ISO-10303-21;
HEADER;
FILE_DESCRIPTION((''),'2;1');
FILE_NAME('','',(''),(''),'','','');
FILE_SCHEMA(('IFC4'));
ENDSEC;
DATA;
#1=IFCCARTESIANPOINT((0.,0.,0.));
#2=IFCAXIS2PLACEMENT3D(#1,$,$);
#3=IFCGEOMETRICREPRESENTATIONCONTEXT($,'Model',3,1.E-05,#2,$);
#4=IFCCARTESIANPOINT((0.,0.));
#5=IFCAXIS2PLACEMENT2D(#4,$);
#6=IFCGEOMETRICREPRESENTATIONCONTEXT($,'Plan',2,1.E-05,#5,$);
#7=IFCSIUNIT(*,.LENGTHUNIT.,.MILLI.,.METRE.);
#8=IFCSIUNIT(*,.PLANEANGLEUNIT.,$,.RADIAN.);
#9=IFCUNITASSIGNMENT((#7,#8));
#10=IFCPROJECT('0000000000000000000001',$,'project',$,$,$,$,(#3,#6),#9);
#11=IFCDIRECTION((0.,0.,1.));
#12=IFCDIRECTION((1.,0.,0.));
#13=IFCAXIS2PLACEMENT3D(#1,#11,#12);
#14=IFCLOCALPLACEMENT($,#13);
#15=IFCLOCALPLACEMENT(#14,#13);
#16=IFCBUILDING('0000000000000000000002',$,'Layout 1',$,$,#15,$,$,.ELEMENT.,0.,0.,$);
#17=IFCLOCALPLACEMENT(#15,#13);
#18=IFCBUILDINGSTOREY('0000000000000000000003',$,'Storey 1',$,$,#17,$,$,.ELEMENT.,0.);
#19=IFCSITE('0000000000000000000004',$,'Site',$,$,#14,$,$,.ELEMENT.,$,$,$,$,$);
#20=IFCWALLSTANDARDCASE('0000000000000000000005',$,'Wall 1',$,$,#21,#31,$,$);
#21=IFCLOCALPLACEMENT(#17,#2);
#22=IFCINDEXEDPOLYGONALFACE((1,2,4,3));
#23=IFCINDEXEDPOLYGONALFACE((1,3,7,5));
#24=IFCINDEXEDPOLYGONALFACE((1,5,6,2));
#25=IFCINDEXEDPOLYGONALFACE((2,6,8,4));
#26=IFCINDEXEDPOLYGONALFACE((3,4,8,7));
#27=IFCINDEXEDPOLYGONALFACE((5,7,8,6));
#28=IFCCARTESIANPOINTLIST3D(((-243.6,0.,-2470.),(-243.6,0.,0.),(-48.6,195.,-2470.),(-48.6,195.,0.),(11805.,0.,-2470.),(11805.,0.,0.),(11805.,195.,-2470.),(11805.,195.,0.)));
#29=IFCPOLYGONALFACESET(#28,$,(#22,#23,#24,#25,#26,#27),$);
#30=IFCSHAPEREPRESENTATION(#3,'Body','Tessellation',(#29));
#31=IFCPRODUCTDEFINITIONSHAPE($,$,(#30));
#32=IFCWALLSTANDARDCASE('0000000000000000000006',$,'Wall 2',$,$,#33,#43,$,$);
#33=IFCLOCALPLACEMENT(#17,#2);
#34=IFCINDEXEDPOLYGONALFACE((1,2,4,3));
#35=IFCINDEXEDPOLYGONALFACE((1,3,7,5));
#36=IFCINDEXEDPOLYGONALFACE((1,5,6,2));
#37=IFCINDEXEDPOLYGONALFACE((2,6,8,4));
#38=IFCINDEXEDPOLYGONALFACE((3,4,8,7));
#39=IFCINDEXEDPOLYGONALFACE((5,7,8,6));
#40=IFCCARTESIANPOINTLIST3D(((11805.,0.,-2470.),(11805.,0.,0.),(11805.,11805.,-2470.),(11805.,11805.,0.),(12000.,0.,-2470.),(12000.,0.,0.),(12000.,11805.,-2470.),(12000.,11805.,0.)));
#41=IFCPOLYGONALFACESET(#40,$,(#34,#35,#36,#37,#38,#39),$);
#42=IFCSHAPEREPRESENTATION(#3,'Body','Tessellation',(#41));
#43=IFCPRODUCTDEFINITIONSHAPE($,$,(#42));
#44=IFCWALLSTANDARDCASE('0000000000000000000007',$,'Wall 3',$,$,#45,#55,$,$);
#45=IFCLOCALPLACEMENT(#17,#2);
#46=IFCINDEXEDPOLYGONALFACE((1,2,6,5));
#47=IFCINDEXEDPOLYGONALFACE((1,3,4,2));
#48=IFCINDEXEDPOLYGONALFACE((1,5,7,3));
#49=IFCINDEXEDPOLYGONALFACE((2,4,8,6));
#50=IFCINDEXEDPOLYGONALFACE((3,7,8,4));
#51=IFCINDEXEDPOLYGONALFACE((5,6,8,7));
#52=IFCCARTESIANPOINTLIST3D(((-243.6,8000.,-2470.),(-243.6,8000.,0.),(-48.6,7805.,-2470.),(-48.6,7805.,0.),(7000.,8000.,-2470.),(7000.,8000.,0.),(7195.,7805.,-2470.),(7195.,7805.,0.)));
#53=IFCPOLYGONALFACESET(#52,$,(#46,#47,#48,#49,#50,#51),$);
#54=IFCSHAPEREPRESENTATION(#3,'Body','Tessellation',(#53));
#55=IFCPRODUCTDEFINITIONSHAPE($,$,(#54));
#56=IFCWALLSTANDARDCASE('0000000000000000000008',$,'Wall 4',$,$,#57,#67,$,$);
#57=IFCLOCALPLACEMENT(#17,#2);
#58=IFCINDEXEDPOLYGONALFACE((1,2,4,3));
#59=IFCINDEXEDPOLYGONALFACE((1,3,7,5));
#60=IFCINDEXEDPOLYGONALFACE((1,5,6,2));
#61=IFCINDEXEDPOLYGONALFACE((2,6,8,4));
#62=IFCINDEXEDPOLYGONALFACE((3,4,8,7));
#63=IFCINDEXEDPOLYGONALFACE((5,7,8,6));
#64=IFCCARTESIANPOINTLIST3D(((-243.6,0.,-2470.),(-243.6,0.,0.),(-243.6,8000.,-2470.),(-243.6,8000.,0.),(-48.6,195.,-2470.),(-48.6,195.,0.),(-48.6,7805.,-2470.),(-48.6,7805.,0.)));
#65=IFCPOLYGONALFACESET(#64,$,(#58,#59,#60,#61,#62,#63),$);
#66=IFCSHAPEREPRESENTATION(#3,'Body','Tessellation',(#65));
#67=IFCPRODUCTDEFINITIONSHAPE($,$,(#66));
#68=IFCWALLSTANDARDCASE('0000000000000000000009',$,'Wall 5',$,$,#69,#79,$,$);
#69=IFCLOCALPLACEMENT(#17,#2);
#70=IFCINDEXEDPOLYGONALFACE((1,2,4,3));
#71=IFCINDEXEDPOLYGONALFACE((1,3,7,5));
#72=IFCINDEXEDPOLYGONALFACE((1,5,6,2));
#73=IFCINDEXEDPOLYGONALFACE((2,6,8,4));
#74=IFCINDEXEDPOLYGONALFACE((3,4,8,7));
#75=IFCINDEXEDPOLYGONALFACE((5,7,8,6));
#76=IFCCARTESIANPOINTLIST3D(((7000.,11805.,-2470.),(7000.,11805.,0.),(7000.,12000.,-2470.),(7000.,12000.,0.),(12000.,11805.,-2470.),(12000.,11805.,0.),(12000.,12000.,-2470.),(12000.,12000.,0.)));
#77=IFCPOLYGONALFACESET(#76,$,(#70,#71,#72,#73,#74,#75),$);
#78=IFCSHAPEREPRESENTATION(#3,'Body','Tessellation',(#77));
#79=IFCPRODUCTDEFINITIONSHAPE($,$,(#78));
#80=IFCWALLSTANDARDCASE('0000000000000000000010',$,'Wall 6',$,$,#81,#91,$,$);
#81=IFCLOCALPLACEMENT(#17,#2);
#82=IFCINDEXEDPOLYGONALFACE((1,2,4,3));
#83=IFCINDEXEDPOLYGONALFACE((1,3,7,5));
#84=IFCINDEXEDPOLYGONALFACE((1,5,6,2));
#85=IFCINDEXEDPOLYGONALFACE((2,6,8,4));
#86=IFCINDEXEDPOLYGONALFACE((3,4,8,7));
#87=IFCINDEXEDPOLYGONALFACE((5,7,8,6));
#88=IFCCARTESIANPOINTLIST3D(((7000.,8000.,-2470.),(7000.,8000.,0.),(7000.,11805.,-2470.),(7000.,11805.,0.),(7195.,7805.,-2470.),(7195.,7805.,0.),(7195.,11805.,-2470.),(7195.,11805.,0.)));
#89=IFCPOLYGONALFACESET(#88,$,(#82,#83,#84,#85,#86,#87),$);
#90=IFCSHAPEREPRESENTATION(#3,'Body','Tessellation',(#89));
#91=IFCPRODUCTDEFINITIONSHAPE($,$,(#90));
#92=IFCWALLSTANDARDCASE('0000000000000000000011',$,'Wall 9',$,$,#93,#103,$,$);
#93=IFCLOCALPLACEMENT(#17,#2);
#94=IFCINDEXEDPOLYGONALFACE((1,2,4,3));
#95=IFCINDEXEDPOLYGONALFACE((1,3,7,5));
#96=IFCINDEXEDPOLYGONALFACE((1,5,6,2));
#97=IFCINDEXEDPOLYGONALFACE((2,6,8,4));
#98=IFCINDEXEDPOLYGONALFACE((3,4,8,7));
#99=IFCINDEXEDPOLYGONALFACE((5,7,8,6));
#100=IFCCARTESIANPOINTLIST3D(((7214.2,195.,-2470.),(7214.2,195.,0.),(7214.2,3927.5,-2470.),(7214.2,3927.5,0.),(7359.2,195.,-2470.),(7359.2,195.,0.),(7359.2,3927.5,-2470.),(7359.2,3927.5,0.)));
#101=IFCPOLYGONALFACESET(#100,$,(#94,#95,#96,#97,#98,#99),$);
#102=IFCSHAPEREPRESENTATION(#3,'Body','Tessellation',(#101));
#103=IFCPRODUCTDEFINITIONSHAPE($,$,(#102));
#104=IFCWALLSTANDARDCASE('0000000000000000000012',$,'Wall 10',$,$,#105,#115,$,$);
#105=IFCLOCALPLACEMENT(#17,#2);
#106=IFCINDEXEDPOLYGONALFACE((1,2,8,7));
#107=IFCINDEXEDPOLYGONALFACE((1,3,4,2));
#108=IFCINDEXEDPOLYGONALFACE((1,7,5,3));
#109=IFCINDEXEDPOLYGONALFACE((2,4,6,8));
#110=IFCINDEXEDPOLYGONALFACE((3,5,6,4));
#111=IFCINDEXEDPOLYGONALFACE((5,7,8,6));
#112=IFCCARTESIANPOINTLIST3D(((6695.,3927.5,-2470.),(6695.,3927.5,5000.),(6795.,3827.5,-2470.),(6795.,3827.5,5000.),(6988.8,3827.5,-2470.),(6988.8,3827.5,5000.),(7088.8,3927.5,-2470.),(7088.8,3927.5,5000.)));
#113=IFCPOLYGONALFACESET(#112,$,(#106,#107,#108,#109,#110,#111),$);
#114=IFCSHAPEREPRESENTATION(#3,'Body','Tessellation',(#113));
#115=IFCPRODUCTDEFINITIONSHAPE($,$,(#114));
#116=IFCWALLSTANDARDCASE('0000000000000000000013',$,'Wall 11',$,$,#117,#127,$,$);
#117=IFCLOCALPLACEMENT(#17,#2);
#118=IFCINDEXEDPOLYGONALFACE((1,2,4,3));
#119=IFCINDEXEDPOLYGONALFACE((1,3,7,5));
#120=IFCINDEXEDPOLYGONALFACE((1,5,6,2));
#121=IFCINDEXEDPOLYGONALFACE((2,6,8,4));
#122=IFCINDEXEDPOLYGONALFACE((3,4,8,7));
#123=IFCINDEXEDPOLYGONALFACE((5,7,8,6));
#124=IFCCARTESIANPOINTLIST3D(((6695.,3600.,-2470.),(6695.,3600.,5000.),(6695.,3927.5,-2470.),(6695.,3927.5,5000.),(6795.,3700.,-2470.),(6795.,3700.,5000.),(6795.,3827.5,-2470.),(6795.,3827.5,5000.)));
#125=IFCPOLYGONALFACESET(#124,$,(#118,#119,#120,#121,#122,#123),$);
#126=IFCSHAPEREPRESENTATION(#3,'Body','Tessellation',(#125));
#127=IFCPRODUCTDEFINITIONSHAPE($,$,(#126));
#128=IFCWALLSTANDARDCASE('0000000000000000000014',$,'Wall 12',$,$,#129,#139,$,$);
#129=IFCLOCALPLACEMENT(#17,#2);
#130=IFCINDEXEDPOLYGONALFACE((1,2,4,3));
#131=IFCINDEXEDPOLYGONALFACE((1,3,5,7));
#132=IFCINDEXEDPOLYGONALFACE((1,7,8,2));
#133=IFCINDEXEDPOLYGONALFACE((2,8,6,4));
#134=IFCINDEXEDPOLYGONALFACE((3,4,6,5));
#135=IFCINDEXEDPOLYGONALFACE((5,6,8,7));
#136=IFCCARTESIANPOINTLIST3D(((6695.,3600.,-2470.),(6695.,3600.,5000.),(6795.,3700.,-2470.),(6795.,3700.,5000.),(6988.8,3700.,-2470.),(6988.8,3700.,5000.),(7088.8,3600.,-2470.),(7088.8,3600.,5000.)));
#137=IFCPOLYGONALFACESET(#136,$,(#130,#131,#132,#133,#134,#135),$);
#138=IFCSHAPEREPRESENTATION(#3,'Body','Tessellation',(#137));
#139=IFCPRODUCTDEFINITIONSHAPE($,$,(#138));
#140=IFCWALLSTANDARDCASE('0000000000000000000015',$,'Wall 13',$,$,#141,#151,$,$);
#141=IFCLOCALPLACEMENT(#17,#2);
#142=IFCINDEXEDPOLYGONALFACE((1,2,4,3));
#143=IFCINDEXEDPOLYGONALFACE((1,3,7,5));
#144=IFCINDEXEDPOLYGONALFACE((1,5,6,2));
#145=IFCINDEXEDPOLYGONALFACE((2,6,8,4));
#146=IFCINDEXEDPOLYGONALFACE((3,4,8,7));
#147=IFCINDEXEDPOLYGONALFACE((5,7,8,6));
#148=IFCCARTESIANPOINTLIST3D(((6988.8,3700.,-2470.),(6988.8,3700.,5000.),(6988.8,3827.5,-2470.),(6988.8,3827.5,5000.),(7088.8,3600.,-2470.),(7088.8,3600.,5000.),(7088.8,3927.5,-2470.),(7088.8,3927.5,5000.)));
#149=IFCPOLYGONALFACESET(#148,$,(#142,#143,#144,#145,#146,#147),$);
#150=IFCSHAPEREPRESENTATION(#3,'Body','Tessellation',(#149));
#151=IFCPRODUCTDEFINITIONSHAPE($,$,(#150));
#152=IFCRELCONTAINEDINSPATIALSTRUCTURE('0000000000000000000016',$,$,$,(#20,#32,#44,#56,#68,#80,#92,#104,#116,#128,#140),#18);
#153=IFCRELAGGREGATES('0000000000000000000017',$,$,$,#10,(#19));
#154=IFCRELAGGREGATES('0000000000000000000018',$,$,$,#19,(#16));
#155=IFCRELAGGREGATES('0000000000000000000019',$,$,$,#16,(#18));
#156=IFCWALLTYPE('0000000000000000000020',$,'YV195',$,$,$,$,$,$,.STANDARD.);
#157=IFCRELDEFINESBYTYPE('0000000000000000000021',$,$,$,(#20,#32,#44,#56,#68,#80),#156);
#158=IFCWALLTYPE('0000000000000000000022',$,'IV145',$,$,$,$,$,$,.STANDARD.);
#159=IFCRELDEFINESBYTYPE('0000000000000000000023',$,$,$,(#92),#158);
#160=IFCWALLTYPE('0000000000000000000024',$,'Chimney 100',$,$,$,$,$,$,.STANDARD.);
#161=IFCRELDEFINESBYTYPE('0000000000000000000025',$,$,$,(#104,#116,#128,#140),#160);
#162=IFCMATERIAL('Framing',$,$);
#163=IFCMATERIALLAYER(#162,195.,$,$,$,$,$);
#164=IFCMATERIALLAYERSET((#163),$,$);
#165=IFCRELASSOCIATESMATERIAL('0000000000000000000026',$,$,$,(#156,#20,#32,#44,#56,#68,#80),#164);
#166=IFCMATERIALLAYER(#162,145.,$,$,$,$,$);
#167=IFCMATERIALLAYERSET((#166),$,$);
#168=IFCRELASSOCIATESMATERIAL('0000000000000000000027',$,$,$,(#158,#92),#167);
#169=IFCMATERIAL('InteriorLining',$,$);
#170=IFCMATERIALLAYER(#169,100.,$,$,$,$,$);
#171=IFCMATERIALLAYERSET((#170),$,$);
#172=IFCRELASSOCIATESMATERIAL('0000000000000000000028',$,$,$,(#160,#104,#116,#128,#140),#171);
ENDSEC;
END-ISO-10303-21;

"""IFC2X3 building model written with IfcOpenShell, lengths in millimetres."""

from ifc_helpers import new_model, si_unit, frame, origin, origin_with_axes, origin_2d, place, context, project, spatial, polyline, segment, composite_curve, outline, extrude, material, layer, layer_set, layer_usage, type_object, element, save


model = new_model("IFC2X3")

# Units and contexts
model_context = context("Model", 3, precision=1e-05, world=origin())
plan_context = context("Plan", 2, precision=1e-05, world=origin_2d())
ifc_project = project(units=[si_unit("LENGTHUNIT", "METRE", prefix="MILLI"), si_unit("PLANEANGLEUNIT", "RADIAN")], contexts=[model_context, plan_context])

# Site, building, storey
site_placement = place(None, origin_with_axes())
site = spatial("IfcSite", under=ifc_project, at=site_placement, Name="Site", CompositionType="ELEMENT")
building_placement = place(site_placement, origin_with_axes())
building = spatial("IfcBuilding", under=site, at=building_placement, Name="Layout 1", CompositionType="ELEMENT", ElevationOfRefHeight=0.0, ElevationOfTerrain=0.0)
storey_placement = place(building_placement, origin_with_axes())
storey = spatial("IfcBuildingStorey", under=building, at=storey_placement, Name="Storey 1", CompositionType="ELEMENT", Elevation=0.0)

# Walls
ifc_material_1 = material(Name="Framing")
ifc_layer_1 = layer(ifc_material_1, 195.0)
ifc_layer_set_1 = layer_set([ifc_layer_1])
ifc_layer_usage_1 = layer_usage(ifc_layer_set_1, "AXIS2", "POSITIVE", 0.0)
wall_type_1 = type_object("IfcWallType", Name="YV195", PredefinedType="STANDARD", material=ifc_layer_set_1)
wall_1_placement = place(storey_placement, frame((-243.6, 0.0, -2470.0), z_axis=(0.0, 0.0, 1.0), x_axis=(1.0, 0.0, 0.0)))
element("IfcWallStandardCase", 1, at=wall_1_placement, inside=storey, type_object=wall_type_1, material=ifc_layer_usage_1, Name="Wall 1", context=model_context, shape_type="SweptSolid", body=[
    extrude(outline(composite_curve([segment(polyline([(195.0, 195.0), (0.0, 0.0)]), True, "CONTINUOUS"), segment(polyline([(0.0, 0.0), (12048.6, 0.0)]), True, "CONTINUOUS"), segment(polyline([(12048.6, 0.0), (12048.6, 195.0)]), True, "CONTINUOUS"), segment(polyline([(12048.6, 195.0), (195.0, 195.0)]), True, "CONTINUOUS")], self_intersect=False)), origin_with_axes(), (0.0, 0.0, 1.0), 2470.0),
])
ifc_layer_usage_2 = layer_usage(ifc_layer_set_1, "AXIS2", "POSITIVE", 0.0)
wall_2_placement = place(storey_placement, frame((12000.0, 0.0, -2470.0), z_axis=(0.0, 0.0, 1.0), x_axis=(0.0, 1.0, 0.0)))
element("IfcWallStandardCase", 2, at=wall_2_placement, inside=storey, type_object=wall_type_1, material=ifc_layer_usage_2, Name="Wall 2", context=model_context, shape_type="SweptSolid", body=[
    extrude(outline(composite_curve([segment(polyline([(0.0, 195.0), (0.0, 0.0)]), True, "CONTINUOUS"), segment(polyline([(0.0, 0.0), (11805.0, 0.0)]), True, "CONTINUOUS"), segment(polyline([(11805.0, 0.0), (11805.0, 195.0)]), True, "CONTINUOUS"), segment(polyline([(11805.0, 195.0), (0.0, 195.0)]), True, "CONTINUOUS")], self_intersect=False)), origin_with_axes(), (0.0, 0.0, 1.0), 2470.0),
])
ifc_layer_usage_3 = layer_usage(ifc_layer_set_1, "AXIS2", "POSITIVE", 0.0)
wall_3_placement = place(storey_placement, frame((7000.0, 8000.0, -2470.0), z_axis=(0.0, 0.0, 1.0), x_axis=(-1.0, 0.0, 0.0)))
element("IfcWallStandardCase", 3, at=wall_3_placement, inside=storey, type_object=wall_type_1, material=ifc_layer_usage_3, Name="Wall 3", context=model_context, shape_type="SweptSolid", body=[
    extrude(outline(composite_curve([segment(polyline([(-195.0, 195.0), (0.0, 0.0)]), True, "CONTINUOUS"), segment(polyline([(0.0, 0.0), (7243.6, 0.0)]), True, "CONTINUOUS"), segment(polyline([(7243.6, 0.0), (7048.6, 195.0)]), True, "CONTINUOUS"), segment(polyline([(7048.6, 195.0), (-195.0, 195.0)]), True, "CONTINUOUS")], self_intersect=False)), origin_with_axes(), (0.0, 0.0, 1.0), 2470.0),
])
ifc_layer_usage_4 = layer_usage(ifc_layer_set_1, "AXIS2", "POSITIVE", 0.0)
wall_4_placement = place(storey_placement, frame((-243.6, 8000.0, -2470.0), z_axis=(0.0, 0.0, 1.0), x_axis=(0.0, -1.0, 0.0)))
element("IfcWallStandardCase", 4, at=wall_4_placement, inside=storey, type_object=wall_type_1, material=ifc_layer_usage_4, Name="Wall 4", context=model_context, shape_type="SweptSolid", body=[
    extrude(outline(composite_curve([segment(polyline([(195.0, 195.0), (0.0, 0.0)]), True, "CONTINUOUS"), segment(polyline([(0.0, 0.0), (8000.0, 0.0)]), True, "CONTINUOUS"), segment(polyline([(8000.0, 0.0), (7805.0, 195.0)]), True, "CONTINUOUS"), segment(polyline([(7805.0, 195.0), (195.0, 195.0)]), True, "CONTINUOUS")], self_intersect=False)), origin_with_axes(), (0.0, 0.0, 1.0), 2470.0),
])
ifc_layer_usage_5 = layer_usage(ifc_layer_set_1, "AXIS2", "POSITIVE", 0.0)
wall_5_placement = place(storey_placement, frame((12000.0, 12000.0, -2470.0), z_axis=(0.0, 0.0, 1.0), x_axis=(-1.0, 0.0, 0.0)))
element("IfcWallStandardCase", 5, at=wall_5_placement, inside=storey, type_object=wall_type_1, material=ifc_layer_usage_5, Name="Wall 5", context=model_context, shape_type="SweptSolid", body=[
    extrude(outline(composite_curve([segment(polyline([(0.0, 195.0), (0.0, 0.0)]), True, "CONTINUOUS"), segment(polyline([(0.0, 0.0), (5000.0, 0.0)]), True, "CONTINUOUS"), segment(polyline([(5000.0, 0.0), (5000.0, 195.0)]), True, "CONTINUOUS"), segment(polyline([(5000.0, 195.0), (0.0, 195.0)]), True, "CONTINUOUS")], self_intersect=False)), origin_with_axes(), (0.0, 0.0, 1.0), 2470.0),
])
ifc_layer_usage_6 = layer_usage(ifc_layer_set_1, "AXIS2", "POSITIVE", 0.0)
wall_6_placement = place(storey_placement, frame((7000.0, 11805.0, -2470.0), z_axis=(0.0, 0.0, 1.0), x_axis=(0.0, -1.0, 0.0)))
element("IfcWallStandardCase", 6, at=wall_6_placement, inside=storey, type_object=wall_type_1, material=ifc_layer_usage_6, Name="Wall 6", context=model_context, shape_type="SweptSolid", body=[
    extrude(outline(composite_curve([segment(polyline([(0.0, 195.0), (0.0, 0.0)]), True, "CONTINUOUS"), segment(polyline([(0.0, 0.0), (3805.0, 0.0)]), True, "CONTINUOUS"), segment(polyline([(3805.0, 0.0), (4000.0, 195.0)]), True, "CONTINUOUS"), segment(polyline([(4000.0, 195.0), (0.0, 195.0)]), True, "CONTINUOUS")], self_intersect=False)), origin_with_axes(), (0.0, 0.0, 1.0), 2470.0),
])
ifc_layer_2 = layer(ifc_material_1, 145.0)
ifc_layer_set_2 = layer_set([ifc_layer_2])
wall_type_2 = type_object("IfcWallType", Name="IV145", PredefinedType="STANDARD", material=ifc_layer_set_2)
ifc_layer_usage_7 = layer_usage(ifc_layer_set_2, "AXIS2", "POSITIVE", -72.5)
wall_7_placement = place(storey_placement, frame((7286.7, 0.0, -2470.0), z_axis=(0.0, 0.0, 1.0), x_axis=(0.0, 1.0, 0.0)))
element("IfcWallStandardCase", 7, at=wall_7_placement, inside=storey, type_object=wall_type_2, material=ifc_layer_usage_7, Name="Wall 9", context=model_context, shape_type="SweptSolid", body=[
    extrude(outline(composite_curve([segment(polyline([(195.0, 72.5), (195.0, -72.5)]), True, "CONTINUOUS"), segment(polyline([(195.0, -72.5), (3927.5, -72.5)]), True, "CONTINUOUS"), segment(polyline([(3927.5, -72.5), (3927.5, 72.5)]), True, "CONTINUOUS"), segment(polyline([(3927.5, 72.5), (195.0, 72.5)]), True, "CONTINUOUS")], self_intersect=False)), origin_with_axes(), (0.0, 0.0, 1.0), 2470.0),
])
ifc_material_2 = material(Name="InteriorLining")
ifc_layer_3 = layer(ifc_material_2, 100.0)
ifc_layer_set_3 = layer_set([ifc_layer_3])
ifc_layer_usage_8 = layer_usage(ifc_layer_set_3, "AXIS2", "POSITIVE", 0.0)
wall_type_3 = type_object("IfcWallType", Name="Chimney 100", PredefinedType="STANDARD", material=ifc_layer_set_3)
wall_8_placement = place(storey_placement, frame((7088.8, 3927.5, -2470.0), z_axis=(0.0, 0.0, 1.0), x_axis=(-1.0, 0.0, 0.0)))
element("IfcWallStandardCase", 8, at=wall_8_placement, inside=storey, type_object=wall_type_3, material=ifc_layer_usage_8, Name="Wall 10", context=model_context, shape_type="SweptSolid", body=[
    extrude(outline(composite_curve([segment(polyline([(100.0, 100.0), (0.0, 0.0)]), True, "CONTINUOUS"), segment(polyline([(0.0, 0.0), (393.8, 0.0)]), True, "CONTINUOUS"), segment(polyline([(393.8, 0.0), (293.8, 100.0)]), True, "CONTINUOUS"), segment(polyline([(293.8, 100.0), (100.0, 100.0)]), True, "CONTINUOUS")], self_intersect=False)), origin_with_axes(), (0.0, 0.0, 1.0), 7470.0),
])
ifc_layer_usage_9 = layer_usage(ifc_layer_set_3, "AXIS2", "POSITIVE", 0.0)
wall_9_placement = place(storey_placement, frame((6695.0, 3927.5, -2470.0), z_axis=(0.0, 0.0, 1.0), x_axis=(0.0, -1.0, 0.0)))
element("IfcWallStandardCase", 9, at=wall_9_placement, inside=storey, type_object=wall_type_3, material=ifc_layer_usage_9, Name="Wall 11", context=model_context, shape_type="SweptSolid", body=[
    extrude(outline(composite_curve([segment(polyline([(100.0, 100.0), (0.0, 0.0)]), True, "CONTINUOUS"), segment(polyline([(0.0, 0.0), (327.5, 0.0)]), True, "CONTINUOUS"), segment(polyline([(327.5, 0.0), (227.5, 100.0)]), True, "CONTINUOUS"), segment(polyline([(227.5, 100.0), (100.0, 100.0)]), True, "CONTINUOUS")], self_intersect=False)), origin_with_axes(), (0.0, 0.0, 1.0), 7470.0),
])
ifc_layer_usage_10 = layer_usage(ifc_layer_set_3, "AXIS2", "POSITIVE", 0.0)
wall_10_placement = place(storey_placement, frame((6695.0, 3600.0, -2470.0), z_axis=(0.0, 0.0, 1.0), x_axis=(1.0, 0.0, 0.0)))
element("IfcWallStandardCase", 10, at=wall_10_placement, inside=storey, type_object=wall_type_3, material=ifc_layer_usage_10, Name="Wall 12", context=model_context, shape_type="SweptSolid", body=[
    extrude(outline(composite_curve([segment(polyline([(100.0, 100.0), (0.0, 0.0)]), True, "CONTINUOUS"), segment(polyline([(0.0, 0.0), (393.8, 0.0)]), True, "CONTINUOUS"), segment(polyline([(393.8, 0.0), (293.8, 100.0)]), True, "CONTINUOUS"), segment(polyline([(293.8, 100.0), (100.0, 100.0)]), True, "CONTINUOUS")], self_intersect=False)), origin_with_axes(), (0.0, 0.0, 1.0), 7470.0),
])
ifc_layer_usage_11 = layer_usage(ifc_layer_set_3, "AXIS2", "POSITIVE", 0.0)
wall_11_placement = place(storey_placement, frame((7088.8, 3600.0, -2470.0), z_axis=(0.0, 0.0, 1.0), x_axis=(0.0, 1.0, 0.0)))
element("IfcWallStandardCase", 11, at=wall_11_placement, inside=storey, type_object=wall_type_3, material=ifc_layer_usage_11, Name="Wall 13", context=model_context, shape_type="SweptSolid", body=[
    extrude(outline(composite_curve([segment(polyline([(100.0, 100.0), (0.0, 0.0)]), True, "CONTINUOUS"), segment(polyline([(0.0, 0.0), (327.5, 0.0)]), True, "CONTINUOUS"), segment(polyline([(327.5, 0.0), (227.5, 100.0)]), True, "CONTINUOUS"), segment(polyline([(227.5, 100.0), (100.0, 100.0)]), True, "CONTINUOUS")], self_intersect=False)), origin_with_axes(), (0.0, 0.0, 1.0), 7470.0),
])

save(model, "model.ifc")
